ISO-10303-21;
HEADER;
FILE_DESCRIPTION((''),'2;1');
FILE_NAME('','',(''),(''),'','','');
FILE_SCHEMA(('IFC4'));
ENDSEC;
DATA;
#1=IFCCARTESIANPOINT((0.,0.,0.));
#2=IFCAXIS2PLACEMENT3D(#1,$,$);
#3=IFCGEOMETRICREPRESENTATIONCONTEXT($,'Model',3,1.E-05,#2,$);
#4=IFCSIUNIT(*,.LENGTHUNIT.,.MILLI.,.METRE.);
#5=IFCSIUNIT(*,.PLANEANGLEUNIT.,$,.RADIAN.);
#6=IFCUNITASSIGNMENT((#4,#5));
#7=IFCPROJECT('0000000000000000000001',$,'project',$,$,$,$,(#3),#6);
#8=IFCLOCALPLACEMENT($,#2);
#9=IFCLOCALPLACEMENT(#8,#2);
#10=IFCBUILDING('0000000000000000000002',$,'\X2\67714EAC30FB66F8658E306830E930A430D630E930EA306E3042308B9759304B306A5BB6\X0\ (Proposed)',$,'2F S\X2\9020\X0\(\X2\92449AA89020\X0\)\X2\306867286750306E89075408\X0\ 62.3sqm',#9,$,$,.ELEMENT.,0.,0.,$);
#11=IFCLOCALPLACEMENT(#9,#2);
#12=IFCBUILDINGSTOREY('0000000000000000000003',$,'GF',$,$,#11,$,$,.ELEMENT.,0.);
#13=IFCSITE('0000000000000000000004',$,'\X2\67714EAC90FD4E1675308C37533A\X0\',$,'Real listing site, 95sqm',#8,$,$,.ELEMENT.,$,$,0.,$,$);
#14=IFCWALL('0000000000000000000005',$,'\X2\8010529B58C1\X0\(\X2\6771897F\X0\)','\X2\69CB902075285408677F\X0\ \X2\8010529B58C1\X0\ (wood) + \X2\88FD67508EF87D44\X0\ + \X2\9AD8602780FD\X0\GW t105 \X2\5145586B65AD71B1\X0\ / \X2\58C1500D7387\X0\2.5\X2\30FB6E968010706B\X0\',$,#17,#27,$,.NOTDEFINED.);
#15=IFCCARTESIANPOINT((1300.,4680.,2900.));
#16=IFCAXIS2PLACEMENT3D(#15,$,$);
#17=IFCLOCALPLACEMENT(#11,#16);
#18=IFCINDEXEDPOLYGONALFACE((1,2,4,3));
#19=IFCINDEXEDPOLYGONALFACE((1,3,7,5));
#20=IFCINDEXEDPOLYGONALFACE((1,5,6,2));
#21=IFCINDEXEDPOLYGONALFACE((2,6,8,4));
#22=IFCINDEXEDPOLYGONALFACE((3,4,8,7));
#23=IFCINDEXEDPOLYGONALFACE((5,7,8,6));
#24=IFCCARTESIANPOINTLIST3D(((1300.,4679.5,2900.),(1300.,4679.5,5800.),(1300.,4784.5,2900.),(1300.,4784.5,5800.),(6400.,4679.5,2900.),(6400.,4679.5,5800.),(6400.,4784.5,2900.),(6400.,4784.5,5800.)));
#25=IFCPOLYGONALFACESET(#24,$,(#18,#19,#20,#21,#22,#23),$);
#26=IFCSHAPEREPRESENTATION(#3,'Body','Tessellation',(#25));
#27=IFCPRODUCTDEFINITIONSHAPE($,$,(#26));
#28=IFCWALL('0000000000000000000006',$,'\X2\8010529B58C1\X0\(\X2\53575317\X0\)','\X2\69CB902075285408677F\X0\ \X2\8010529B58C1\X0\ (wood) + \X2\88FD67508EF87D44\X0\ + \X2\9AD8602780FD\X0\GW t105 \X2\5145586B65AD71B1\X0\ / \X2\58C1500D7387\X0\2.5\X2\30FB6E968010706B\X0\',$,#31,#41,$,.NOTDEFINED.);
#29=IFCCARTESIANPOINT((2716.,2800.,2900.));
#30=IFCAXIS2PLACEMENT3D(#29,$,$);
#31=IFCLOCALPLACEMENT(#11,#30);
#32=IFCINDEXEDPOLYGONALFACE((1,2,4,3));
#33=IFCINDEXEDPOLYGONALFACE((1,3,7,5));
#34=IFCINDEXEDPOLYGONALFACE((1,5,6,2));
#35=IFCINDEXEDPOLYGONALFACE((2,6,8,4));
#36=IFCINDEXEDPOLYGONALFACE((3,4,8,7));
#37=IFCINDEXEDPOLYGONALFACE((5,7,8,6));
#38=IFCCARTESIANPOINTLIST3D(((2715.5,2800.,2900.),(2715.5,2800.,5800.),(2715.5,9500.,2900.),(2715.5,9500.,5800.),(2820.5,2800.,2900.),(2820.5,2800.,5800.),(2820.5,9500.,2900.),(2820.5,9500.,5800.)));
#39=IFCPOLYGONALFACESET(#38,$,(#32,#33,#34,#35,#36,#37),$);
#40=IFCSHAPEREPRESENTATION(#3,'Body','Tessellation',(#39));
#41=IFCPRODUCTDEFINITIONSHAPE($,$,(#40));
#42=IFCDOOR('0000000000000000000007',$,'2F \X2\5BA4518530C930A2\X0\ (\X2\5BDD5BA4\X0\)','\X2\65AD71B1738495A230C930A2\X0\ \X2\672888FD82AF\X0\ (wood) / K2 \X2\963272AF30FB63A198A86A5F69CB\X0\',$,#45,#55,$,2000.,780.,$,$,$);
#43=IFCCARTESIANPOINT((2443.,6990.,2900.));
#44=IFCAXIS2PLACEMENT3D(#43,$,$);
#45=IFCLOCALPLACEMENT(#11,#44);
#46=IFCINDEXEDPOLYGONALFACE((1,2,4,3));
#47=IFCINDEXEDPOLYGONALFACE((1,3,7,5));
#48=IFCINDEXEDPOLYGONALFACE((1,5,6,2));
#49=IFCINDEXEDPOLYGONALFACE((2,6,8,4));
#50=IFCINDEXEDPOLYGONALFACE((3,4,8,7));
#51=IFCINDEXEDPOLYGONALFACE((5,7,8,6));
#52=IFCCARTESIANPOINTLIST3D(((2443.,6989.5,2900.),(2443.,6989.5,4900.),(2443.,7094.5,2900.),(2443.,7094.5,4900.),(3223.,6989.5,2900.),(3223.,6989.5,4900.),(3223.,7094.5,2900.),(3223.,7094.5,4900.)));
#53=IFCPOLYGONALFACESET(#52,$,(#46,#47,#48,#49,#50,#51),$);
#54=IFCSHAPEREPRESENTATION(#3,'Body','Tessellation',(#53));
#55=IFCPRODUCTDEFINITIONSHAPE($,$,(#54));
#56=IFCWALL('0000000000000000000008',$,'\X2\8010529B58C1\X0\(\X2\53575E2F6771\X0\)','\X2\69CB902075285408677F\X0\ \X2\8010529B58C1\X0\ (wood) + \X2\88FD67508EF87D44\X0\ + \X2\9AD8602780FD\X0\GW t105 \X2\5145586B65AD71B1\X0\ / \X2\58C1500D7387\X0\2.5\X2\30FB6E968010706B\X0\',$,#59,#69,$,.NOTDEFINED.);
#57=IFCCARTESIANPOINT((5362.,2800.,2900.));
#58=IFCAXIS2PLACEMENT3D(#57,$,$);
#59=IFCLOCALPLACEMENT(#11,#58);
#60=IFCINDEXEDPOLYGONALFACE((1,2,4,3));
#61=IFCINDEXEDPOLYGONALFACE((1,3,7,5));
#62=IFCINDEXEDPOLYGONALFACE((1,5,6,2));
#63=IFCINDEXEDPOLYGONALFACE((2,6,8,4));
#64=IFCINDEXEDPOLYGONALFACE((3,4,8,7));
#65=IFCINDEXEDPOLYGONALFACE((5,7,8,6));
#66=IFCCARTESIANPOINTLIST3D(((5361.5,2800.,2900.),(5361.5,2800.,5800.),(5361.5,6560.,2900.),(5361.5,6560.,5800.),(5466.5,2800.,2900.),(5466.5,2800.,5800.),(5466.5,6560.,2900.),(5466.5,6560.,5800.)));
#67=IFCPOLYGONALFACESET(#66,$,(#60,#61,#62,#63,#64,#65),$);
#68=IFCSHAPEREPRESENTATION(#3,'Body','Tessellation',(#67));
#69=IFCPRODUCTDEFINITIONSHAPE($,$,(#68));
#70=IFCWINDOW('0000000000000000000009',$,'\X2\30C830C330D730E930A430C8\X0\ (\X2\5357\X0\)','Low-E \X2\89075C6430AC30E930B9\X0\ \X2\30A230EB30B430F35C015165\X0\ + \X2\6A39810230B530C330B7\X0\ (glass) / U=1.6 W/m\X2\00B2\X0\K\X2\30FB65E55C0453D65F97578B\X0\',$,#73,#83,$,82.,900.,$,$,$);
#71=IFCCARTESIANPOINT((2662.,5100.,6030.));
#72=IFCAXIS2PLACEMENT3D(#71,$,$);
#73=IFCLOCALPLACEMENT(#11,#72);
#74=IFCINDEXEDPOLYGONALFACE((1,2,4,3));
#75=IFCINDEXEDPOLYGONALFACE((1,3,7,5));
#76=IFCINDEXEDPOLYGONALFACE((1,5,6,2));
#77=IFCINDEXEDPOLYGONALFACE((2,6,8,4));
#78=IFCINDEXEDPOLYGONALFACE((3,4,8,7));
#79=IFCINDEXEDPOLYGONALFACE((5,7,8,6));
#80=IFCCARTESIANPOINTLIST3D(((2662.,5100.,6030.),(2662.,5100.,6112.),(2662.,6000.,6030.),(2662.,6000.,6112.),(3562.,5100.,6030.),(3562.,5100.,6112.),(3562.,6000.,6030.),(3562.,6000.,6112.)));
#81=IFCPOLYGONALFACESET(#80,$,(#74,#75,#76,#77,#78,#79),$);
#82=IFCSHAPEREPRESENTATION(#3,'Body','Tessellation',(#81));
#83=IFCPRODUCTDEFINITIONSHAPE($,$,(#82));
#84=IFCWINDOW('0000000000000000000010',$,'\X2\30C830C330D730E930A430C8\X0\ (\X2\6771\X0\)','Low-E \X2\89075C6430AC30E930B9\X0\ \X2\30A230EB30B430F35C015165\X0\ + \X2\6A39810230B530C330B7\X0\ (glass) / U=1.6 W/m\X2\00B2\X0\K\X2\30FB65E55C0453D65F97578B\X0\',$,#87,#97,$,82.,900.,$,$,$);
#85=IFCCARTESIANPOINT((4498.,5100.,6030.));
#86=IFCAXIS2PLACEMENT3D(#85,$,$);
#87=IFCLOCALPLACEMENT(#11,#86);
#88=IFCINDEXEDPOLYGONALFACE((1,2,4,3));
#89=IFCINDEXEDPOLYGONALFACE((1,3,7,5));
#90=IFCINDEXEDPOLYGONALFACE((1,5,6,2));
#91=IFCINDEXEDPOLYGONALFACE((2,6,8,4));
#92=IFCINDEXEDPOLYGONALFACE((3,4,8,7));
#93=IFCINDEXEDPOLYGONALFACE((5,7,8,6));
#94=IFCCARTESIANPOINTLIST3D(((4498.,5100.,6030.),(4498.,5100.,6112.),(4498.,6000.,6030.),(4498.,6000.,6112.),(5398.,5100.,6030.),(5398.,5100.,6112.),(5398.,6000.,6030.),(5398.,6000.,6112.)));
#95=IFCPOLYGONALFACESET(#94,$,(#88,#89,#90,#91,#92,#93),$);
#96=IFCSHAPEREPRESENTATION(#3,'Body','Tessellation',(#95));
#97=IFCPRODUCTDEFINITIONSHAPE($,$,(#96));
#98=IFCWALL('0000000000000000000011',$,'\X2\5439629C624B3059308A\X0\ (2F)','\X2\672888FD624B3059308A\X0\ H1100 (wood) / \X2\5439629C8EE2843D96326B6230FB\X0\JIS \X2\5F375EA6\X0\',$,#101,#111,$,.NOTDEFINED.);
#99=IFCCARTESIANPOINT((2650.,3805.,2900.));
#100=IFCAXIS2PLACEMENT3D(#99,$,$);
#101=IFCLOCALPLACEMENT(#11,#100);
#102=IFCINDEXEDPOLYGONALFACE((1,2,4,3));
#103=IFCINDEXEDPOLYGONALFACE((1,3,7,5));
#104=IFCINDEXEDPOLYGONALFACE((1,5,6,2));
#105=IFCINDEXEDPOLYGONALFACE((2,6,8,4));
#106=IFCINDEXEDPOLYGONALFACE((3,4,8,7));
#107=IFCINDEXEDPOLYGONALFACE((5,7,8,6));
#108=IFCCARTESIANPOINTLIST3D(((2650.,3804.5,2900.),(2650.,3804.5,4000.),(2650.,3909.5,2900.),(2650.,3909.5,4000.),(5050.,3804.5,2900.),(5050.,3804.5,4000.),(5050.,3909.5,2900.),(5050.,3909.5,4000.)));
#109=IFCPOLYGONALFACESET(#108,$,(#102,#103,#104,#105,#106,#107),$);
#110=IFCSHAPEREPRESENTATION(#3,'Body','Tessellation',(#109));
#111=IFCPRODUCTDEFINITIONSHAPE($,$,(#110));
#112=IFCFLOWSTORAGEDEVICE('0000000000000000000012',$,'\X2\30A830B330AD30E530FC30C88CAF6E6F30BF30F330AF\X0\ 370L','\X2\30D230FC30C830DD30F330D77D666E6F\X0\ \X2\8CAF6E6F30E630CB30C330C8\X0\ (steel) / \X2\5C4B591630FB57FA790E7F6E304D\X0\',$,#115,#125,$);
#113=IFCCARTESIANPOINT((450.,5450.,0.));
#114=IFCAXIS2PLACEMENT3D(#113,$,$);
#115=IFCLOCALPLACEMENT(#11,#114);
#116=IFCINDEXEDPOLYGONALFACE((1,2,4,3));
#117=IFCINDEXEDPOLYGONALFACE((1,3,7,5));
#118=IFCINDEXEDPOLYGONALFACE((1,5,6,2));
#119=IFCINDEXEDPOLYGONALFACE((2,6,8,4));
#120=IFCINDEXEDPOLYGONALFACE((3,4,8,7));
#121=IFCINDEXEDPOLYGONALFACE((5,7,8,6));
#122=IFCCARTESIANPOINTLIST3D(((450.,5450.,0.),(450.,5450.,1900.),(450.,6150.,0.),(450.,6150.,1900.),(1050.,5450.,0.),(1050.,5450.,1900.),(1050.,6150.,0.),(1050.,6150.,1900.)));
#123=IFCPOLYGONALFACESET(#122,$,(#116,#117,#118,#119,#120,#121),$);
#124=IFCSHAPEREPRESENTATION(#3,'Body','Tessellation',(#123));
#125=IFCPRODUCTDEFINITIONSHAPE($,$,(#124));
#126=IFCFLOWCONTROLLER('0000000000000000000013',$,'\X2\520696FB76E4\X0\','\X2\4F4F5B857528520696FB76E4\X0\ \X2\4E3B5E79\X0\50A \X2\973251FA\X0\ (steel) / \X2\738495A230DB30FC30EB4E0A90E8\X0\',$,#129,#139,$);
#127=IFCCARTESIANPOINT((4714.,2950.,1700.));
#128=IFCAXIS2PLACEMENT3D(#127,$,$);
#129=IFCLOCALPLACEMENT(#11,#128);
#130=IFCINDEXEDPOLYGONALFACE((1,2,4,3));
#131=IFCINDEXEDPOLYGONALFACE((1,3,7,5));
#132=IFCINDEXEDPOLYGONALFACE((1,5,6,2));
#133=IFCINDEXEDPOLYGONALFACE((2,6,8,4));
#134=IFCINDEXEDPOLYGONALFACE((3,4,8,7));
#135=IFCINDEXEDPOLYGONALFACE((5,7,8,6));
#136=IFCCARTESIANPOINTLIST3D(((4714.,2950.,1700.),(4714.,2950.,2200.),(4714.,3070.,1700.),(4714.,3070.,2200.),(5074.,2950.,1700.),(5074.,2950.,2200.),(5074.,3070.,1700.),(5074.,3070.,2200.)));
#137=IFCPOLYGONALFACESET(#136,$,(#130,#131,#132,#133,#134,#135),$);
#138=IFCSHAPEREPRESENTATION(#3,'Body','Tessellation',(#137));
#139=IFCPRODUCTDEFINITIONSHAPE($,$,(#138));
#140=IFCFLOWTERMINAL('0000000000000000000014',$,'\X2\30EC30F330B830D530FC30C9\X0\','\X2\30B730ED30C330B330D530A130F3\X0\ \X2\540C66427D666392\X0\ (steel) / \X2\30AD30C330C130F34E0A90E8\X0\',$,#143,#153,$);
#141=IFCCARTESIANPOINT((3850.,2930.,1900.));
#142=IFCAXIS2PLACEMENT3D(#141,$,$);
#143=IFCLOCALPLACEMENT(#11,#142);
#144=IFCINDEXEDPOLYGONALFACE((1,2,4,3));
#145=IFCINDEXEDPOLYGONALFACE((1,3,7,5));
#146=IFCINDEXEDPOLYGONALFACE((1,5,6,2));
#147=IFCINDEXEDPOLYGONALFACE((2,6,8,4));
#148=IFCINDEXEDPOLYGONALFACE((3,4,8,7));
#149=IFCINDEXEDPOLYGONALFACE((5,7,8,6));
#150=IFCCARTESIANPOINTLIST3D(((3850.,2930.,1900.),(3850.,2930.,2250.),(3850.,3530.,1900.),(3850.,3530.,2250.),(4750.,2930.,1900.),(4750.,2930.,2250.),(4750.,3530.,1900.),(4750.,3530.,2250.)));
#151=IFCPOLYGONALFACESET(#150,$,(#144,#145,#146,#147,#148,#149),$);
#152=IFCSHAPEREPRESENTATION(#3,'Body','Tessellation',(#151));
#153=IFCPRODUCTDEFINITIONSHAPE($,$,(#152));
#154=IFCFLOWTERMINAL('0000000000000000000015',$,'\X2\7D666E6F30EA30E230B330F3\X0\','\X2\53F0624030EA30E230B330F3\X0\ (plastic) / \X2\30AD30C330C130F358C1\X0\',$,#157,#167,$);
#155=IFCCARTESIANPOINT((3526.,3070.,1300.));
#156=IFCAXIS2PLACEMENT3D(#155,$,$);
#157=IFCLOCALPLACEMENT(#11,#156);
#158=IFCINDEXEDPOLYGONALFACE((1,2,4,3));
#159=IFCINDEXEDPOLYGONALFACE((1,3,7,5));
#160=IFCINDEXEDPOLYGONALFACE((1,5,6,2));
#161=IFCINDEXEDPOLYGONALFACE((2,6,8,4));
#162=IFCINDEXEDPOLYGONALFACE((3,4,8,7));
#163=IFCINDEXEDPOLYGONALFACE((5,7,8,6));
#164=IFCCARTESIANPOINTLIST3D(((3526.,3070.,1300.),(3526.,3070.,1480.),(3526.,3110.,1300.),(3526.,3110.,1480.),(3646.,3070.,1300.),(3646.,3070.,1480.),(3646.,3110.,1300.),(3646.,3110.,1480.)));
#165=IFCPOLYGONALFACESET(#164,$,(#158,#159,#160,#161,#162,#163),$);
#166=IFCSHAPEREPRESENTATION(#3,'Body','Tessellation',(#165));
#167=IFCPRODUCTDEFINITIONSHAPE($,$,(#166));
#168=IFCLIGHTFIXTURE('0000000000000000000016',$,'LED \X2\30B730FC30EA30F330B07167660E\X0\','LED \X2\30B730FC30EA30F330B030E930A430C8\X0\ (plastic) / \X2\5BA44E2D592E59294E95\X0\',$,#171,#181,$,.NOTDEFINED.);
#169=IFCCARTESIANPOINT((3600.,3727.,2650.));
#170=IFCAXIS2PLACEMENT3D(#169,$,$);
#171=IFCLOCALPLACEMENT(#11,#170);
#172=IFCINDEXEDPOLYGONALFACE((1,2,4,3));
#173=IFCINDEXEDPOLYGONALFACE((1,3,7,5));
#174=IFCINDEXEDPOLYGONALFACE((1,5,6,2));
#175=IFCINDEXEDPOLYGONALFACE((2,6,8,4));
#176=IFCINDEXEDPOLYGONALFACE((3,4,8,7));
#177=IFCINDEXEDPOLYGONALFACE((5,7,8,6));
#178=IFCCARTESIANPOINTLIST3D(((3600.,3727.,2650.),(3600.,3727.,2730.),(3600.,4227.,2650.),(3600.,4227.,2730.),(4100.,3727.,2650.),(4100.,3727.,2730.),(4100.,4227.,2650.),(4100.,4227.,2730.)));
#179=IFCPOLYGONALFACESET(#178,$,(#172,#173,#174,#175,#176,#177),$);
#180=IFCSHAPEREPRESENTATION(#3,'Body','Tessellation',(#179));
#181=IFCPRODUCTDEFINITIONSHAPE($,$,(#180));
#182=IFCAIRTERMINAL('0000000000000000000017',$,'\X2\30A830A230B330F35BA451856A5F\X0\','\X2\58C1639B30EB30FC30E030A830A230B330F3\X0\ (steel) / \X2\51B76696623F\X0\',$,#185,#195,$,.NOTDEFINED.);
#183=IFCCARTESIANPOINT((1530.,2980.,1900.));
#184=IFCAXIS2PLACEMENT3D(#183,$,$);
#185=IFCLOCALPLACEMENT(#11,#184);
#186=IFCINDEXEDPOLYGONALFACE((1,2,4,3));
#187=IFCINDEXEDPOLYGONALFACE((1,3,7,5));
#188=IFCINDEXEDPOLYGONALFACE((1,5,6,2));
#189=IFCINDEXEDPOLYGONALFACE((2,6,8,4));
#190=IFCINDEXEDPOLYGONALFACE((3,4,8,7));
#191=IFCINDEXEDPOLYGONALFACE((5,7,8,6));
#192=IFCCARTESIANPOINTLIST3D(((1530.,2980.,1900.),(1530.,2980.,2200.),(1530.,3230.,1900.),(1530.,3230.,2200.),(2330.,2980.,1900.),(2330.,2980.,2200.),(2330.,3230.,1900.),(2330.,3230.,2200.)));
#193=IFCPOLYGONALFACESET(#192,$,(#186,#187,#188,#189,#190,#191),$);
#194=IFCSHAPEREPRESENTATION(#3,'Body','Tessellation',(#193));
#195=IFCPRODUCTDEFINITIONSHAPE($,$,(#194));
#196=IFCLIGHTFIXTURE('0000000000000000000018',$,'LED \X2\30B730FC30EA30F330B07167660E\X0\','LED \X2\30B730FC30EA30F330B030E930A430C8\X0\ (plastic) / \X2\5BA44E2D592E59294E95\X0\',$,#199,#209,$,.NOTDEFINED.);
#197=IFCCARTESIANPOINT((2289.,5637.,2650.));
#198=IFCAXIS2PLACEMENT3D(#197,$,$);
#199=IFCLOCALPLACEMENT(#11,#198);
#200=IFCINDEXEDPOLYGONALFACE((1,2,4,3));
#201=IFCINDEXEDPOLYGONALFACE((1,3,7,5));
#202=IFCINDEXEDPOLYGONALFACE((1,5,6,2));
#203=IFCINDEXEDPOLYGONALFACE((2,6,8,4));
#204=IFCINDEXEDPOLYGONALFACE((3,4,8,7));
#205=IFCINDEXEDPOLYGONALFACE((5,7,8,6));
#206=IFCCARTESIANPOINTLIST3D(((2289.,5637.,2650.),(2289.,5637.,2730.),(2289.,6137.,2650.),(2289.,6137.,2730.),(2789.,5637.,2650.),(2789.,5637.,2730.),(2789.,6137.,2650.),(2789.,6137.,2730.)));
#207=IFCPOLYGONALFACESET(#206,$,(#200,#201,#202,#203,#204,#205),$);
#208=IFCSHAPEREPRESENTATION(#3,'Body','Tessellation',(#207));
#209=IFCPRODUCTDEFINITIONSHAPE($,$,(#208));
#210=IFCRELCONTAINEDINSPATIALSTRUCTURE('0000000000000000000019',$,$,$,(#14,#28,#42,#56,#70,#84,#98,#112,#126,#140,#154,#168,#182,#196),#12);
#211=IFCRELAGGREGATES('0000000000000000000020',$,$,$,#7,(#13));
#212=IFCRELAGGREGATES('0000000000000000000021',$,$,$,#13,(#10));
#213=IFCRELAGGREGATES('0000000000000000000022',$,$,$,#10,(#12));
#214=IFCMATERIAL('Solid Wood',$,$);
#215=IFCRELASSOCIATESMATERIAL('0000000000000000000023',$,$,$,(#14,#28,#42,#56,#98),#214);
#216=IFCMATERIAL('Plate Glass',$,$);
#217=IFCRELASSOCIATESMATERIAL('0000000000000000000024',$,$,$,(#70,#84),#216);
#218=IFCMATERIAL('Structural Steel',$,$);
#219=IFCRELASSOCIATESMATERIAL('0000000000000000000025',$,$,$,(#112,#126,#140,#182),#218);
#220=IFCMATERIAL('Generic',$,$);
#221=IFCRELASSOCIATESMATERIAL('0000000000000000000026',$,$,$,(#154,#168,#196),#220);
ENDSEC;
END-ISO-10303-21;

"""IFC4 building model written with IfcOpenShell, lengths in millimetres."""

from ifc_helpers import new_model, si_unit, frame, frame_2d, origin, place, context, project, spatial, rectangle, extrude, material, element, fill, save


model = new_model("IFC4")

# Units and contexts
model_context = context("Model", 3, precision=1e-05, world=origin())
ifc_project = project(units=[si_unit("LENGTHUNIT", "METRE", prefix="MILLI"), si_unit("PLANEANGLEUNIT", "RADIAN")], contexts=[model_context])

# Site, building, storey
site_placement = place(None, origin())
site = spatial("IfcSite", under=ifc_project, at=site_placement, Name="東京都世田谷区", ObjectType="Real listing site, 95sqm", CompositionType="ELEMENT", RefElevation=0.0)
building_placement = place(site_placement, origin())
building = spatial("IfcBuilding", under=site, at=building_placement, Name="東京・書斎とライブラリのある静かな家 (Proposed)", ObjectType="2F S造(鉄骨造)と木材の複合 62.3sqm", CompositionType="ELEMENT", ElevationOfRefHeight=0.0, ElevationOfTerrain=0.0)
storey_placement = place(building_placement, origin())
storey = spatial("IfcBuildingStorey", under=building, at=storey_placement, Name="GF", CompositionType="ELEMENT", Elevation=0.0)

# Shared definitions
ifc_material_1 = material(Name="Solid Wood")

# Wall
wall_1_placement = place(storey_placement, frame((1300.0, 4680.0, 2900.0)))
element("IfcWall", 1, at=wall_1_placement, inside=storey, material=ifc_material_1, Name="耐力壁(東西)", Description="構造用合板 耐力壁 (wood) + 製材軸組 + 高性能GW t105 充填断熱 / 壁倍率2.5・準耐火", PredefinedType="NOTDEFINED", context=model_context, shape_type="SweptSolid", body=[
    extrude(rectangle(XDim=5100.0, YDim=105.0, at=frame_2d((2550.0, 52.0))), frame((1300.0, 4680.0, 2900.0)), (0.0, 0.0, 1.0), 2900.0),
])

# Wall, opening, door
wall_2_placement = place(storey_placement, frame((2716.0, 2800.0, 2900.0)))
wall_2 = element("IfcWall", 2, at=wall_2_placement, inside=storey, material=ifc_material_1, Name="耐力壁(南北)", Description="構造用合板 耐力壁 (wood) + 製材軸組 + 高性能GW t105 充填断熱 / 壁倍率2.5・準耐火", PredefinedType="NOTDEFINED", context=model_context, shape_type="SweptSolid", body=[
    extrude(rectangle(XDim=105.0, YDim=6700.0, at=frame_2d((52.0, 3350.0))), frame((2716.0, 2800.0, 2900.0)), (0.0, 0.0, 1.0), 2900.0),
])
opening_placement = place(storey_placement, frame((2443.0, 6990.0, 2900.0)))
opening = element("IfcOpeningElement", 3, at=opening_placement, cuts=wall_2, PredefinedType="NOTDEFINED", context=model_context, shape_type="SweptSolid", body=[
    extrude(rectangle(XDim=780.0, YDim=105.0, at=frame_2d((390.0, 52.0))), frame((2443.0, 6990.0, 2900.0)), (0.0, 0.0, 1.0), 2000.0),
])
door_placement = place(storey_placement, frame((2443.0, 6990.0, 2900.0)))
door = element("IfcDoor", 4, at=door_placement, inside=storey, material=ifc_material_1, Name="2F 室内ドア (寝室)", Description="断熱玄関ドア 木製芯 (wood) / K2 防犯・採風機構", OverallHeight=2000.0, OverallWidth=780.0, context=model_context, shape_type="SweptSolid", body=[
    extrude(rectangle(XDim=780.0, YDim=105.0, at=frame_2d((390.0, 52.0))), frame((2443.0, 6990.0, 2900.0)), (0.0, 0.0, 1.0), 2000.0),
])
fill(opening, door)

# Wall
wall_3_placement = place(storey_placement, frame((5362.0, 2800.0, 2900.0)))
element("IfcWall", 5, at=wall_3_placement, inside=storey, material=ifc_material_1, Name="耐力壁(南帯東)", Description="構造用合板 耐力壁 (wood) + 製材軸組 + 高性能GW t105 充填断熱 / 壁倍率2.5・準耐火", PredefinedType="NOTDEFINED", context=model_context, shape_type="SweptSolid", body=[
    extrude(rectangle(XDim=105.0, YDim=3760.0, at=frame_2d((52.0, 1880.0))), frame((5362.0, 2800.0, 2900.0)), (0.0, 0.0, 1.0), 2900.0),
])

# Windows
ifc_material_2 = material(Name="Plate Glass")
window_1_placement = place(storey_placement, frame((2662.0, 5100.0, 6030.0)))
element("IfcWindow", 6, at=window_1_placement, inside=storey, material=ifc_material_2, Name="トップライト (南)", Description="Low-E 複層ガラス アルゴン封入 + 樹脂サッシ (glass) / U=1.6 W/m²K・日射取得型", OverallHeight=82.0, OverallWidth=900.0, context=model_context, shape_type="SweptSolid", body=[
    extrude(rectangle(XDim=900.0, YDim=900.0, at=frame_2d((450.0, 450.0))), frame((2662.0, 5100.0, 6030.0)), (0.0, 0.0, 1.0), 82.0),
])
window_2_placement = place(storey_placement, frame((4498.0, 5100.0, 6030.0)))
element("IfcWindow", 7, at=window_2_placement, inside=storey, material=ifc_material_2, Name="トップライト (東)", Description="Low-E 複層ガラス アルゴン封入 + 樹脂サッシ (glass) / U=1.6 W/m²K・日射取得型", OverallHeight=82.0, OverallWidth=900.0, context=model_context, shape_type="SweptSolid", body=[
    extrude(rectangle(XDim=900.0, YDim=900.0, at=frame_2d((450.0, 450.0))), frame((4498.0, 5100.0, 6030.0)), (0.0, 0.0, 1.0), 82.0),
])

# Wall
wall_4_placement = place(storey_placement, frame((2650.0, 3805.0, 2900.0)))
element("IfcWall", 8, at=wall_4_placement, inside=storey, material=ifc_material_1, Name="吹抜手すり (2F)", Description="木製手すり H1100 (wood) / 吹抜転落防止・JIS 強度", PredefinedType="NOTDEFINED", context=model_context, shape_type="SweptSolid", body=[
    extrude(rectangle(XDim=2400.0, YDim=105.0, at=frame_2d((1200.0, 52.0))), frame((2650.0, 3805.0, 2900.0)), (0.0, 0.0, 1.0), 1100.0),
])

# Flow storage device
ifc_material_3 = material(Name="Structural Steel")
flow_storage_device_placement = place(storey_placement, frame((450.0, 5450.0, 0.0)))
element("IfcFlowStorageDevice", 9, at=flow_storage_device_placement, inside=storey, material=ifc_material_3, Name="エコキュート貯湯タンク 370L", Description="ヒートポンプ給湯 貯湯ユニット (steel) / 屋外・基礎置き", context=model_context, shape_type="SweptSolid", body=[
    extrude(rectangle(XDim=600.0, YDim=700.0, at=frame_2d((300.0, 350.0))), frame((450.0, 5450.0, 0.0)), (0.0, 0.0, 1.0), 1900.0),
])

# Flow controller
flow_controller_placement = place(storey_placement, frame((4714.0, 2950.0, 1700.0)))
element("IfcFlowController", 10, at=flow_controller_placement, inside=storey, material=ifc_material_3, Name="分電盤", Description="住宅用分電盤 主幹50A 露出 (steel) / 玄関ホール上部", context=model_context, shape_type="SweptSolid", body=[
    extrude(rectangle(XDim=360.0, YDim=120.0, at=frame_2d((180.0, 60.0))), frame((4714.0, 2950.0, 1700.0)), (0.0, 0.0, 1.0), 500.0),
])

# Flow terminals
flow_terminal_1_placement = place(storey_placement, frame((3850.0, 2930.0, 1900.0)))
element("IfcFlowTerminal", 11, at=flow_terminal_1_placement, inside=storey, material=ifc_material_3, Name="レンジフード", Description="シロッコファン 同時給排 (steel) / キッチン上部", context=model_context, shape_type="SweptSolid", body=[
    extrude(rectangle(XDim=900.0, YDim=600.0, at=frame_2d((450.0, 300.0))), frame((3850.0, 2930.0, 1900.0)), (0.0, 0.0, 1.0), 350.0),
])
ifc_material_4 = material(Name="Generic")
flow_terminal_2_placement = place(storey_placement, frame((3526.0, 3070.0, 1300.0)))
element("IfcFlowTerminal", 12, at=flow_terminal_2_placement, inside=storey, material=ifc_material_4, Name="給湯リモコン", Description="台所リモコン (plastic) / キッチン壁", context=model_context, shape_type="SweptSolid", body=[
    extrude(rectangle(XDim=120.0, YDim=40.0, at=frame_2d((60.0, 20.0))), frame((3526.0, 3070.0, 1300.0)), (0.0, 0.0, 1.0), 180.0),
])

# Light fixture
light_fixture_1_placement = place(storey_placement, frame((3600.0, 3727.0, 2650.0)))
element("IfcLightFixture", 13, at=light_fixture_1_placement, inside=storey, material=ifc_material_4, Name="LED シーリング照明", Description="LED シーリングライト (plastic) / 室中央天井", PredefinedType="NOTDEFINED", context=model_context, shape_type="SweptSolid", body=[
    extrude(rectangle(XDim=500.0, YDim=500.0, at=frame_2d((250.0, 250.0))), frame((3600.0, 3727.0, 2650.0)), (0.0, 0.0, 1.0), 80.0),
])

# Air terminal
air_terminal_1_placement = place(storey_placement, frame((1530.0, 2980.0, 1900.0)))
element("IfcAirTerminal", 14, at=air_terminal_1_placement, inside=storey, material=ifc_material_3, Name="エアコン室内機", Description="壁掛ルームエアコン (steel) / 冷暖房", PredefinedType="NOTDEFINED", context=model_context, shape_type="SweptSolid", body=[
    extrude(rectangle(XDim=800.0, YDim=250.0, at=frame_2d((400.0, 125.0))), frame((1530.0, 2980.0, 1900.0)), (0.0, 0.0, 1.0), 300.0),
])

# Light fixture
light_fixture_2_placement = place(storey_placement, frame((2289.0, 5637.0, 2650.0)))
element("IfcLightFixture", 15, at=light_fixture_2_placement, inside=storey, material=ifc_material_4, Name="LED シーリング照明", Description="LED シーリングライト (plastic) / 室中央天井", PredefinedType="NOTDEFINED", context=model_context, shape_type="SweptSolid", body=[
    extrude(rectangle(XDim=500.0, YDim=500.0, at=frame_2d((250.0, 250.0))), frame((2289.0, 5637.0, 2650.0)), (0.0, 0.0, 1.0), 80.0),
])

save(model, "model.ifc")
